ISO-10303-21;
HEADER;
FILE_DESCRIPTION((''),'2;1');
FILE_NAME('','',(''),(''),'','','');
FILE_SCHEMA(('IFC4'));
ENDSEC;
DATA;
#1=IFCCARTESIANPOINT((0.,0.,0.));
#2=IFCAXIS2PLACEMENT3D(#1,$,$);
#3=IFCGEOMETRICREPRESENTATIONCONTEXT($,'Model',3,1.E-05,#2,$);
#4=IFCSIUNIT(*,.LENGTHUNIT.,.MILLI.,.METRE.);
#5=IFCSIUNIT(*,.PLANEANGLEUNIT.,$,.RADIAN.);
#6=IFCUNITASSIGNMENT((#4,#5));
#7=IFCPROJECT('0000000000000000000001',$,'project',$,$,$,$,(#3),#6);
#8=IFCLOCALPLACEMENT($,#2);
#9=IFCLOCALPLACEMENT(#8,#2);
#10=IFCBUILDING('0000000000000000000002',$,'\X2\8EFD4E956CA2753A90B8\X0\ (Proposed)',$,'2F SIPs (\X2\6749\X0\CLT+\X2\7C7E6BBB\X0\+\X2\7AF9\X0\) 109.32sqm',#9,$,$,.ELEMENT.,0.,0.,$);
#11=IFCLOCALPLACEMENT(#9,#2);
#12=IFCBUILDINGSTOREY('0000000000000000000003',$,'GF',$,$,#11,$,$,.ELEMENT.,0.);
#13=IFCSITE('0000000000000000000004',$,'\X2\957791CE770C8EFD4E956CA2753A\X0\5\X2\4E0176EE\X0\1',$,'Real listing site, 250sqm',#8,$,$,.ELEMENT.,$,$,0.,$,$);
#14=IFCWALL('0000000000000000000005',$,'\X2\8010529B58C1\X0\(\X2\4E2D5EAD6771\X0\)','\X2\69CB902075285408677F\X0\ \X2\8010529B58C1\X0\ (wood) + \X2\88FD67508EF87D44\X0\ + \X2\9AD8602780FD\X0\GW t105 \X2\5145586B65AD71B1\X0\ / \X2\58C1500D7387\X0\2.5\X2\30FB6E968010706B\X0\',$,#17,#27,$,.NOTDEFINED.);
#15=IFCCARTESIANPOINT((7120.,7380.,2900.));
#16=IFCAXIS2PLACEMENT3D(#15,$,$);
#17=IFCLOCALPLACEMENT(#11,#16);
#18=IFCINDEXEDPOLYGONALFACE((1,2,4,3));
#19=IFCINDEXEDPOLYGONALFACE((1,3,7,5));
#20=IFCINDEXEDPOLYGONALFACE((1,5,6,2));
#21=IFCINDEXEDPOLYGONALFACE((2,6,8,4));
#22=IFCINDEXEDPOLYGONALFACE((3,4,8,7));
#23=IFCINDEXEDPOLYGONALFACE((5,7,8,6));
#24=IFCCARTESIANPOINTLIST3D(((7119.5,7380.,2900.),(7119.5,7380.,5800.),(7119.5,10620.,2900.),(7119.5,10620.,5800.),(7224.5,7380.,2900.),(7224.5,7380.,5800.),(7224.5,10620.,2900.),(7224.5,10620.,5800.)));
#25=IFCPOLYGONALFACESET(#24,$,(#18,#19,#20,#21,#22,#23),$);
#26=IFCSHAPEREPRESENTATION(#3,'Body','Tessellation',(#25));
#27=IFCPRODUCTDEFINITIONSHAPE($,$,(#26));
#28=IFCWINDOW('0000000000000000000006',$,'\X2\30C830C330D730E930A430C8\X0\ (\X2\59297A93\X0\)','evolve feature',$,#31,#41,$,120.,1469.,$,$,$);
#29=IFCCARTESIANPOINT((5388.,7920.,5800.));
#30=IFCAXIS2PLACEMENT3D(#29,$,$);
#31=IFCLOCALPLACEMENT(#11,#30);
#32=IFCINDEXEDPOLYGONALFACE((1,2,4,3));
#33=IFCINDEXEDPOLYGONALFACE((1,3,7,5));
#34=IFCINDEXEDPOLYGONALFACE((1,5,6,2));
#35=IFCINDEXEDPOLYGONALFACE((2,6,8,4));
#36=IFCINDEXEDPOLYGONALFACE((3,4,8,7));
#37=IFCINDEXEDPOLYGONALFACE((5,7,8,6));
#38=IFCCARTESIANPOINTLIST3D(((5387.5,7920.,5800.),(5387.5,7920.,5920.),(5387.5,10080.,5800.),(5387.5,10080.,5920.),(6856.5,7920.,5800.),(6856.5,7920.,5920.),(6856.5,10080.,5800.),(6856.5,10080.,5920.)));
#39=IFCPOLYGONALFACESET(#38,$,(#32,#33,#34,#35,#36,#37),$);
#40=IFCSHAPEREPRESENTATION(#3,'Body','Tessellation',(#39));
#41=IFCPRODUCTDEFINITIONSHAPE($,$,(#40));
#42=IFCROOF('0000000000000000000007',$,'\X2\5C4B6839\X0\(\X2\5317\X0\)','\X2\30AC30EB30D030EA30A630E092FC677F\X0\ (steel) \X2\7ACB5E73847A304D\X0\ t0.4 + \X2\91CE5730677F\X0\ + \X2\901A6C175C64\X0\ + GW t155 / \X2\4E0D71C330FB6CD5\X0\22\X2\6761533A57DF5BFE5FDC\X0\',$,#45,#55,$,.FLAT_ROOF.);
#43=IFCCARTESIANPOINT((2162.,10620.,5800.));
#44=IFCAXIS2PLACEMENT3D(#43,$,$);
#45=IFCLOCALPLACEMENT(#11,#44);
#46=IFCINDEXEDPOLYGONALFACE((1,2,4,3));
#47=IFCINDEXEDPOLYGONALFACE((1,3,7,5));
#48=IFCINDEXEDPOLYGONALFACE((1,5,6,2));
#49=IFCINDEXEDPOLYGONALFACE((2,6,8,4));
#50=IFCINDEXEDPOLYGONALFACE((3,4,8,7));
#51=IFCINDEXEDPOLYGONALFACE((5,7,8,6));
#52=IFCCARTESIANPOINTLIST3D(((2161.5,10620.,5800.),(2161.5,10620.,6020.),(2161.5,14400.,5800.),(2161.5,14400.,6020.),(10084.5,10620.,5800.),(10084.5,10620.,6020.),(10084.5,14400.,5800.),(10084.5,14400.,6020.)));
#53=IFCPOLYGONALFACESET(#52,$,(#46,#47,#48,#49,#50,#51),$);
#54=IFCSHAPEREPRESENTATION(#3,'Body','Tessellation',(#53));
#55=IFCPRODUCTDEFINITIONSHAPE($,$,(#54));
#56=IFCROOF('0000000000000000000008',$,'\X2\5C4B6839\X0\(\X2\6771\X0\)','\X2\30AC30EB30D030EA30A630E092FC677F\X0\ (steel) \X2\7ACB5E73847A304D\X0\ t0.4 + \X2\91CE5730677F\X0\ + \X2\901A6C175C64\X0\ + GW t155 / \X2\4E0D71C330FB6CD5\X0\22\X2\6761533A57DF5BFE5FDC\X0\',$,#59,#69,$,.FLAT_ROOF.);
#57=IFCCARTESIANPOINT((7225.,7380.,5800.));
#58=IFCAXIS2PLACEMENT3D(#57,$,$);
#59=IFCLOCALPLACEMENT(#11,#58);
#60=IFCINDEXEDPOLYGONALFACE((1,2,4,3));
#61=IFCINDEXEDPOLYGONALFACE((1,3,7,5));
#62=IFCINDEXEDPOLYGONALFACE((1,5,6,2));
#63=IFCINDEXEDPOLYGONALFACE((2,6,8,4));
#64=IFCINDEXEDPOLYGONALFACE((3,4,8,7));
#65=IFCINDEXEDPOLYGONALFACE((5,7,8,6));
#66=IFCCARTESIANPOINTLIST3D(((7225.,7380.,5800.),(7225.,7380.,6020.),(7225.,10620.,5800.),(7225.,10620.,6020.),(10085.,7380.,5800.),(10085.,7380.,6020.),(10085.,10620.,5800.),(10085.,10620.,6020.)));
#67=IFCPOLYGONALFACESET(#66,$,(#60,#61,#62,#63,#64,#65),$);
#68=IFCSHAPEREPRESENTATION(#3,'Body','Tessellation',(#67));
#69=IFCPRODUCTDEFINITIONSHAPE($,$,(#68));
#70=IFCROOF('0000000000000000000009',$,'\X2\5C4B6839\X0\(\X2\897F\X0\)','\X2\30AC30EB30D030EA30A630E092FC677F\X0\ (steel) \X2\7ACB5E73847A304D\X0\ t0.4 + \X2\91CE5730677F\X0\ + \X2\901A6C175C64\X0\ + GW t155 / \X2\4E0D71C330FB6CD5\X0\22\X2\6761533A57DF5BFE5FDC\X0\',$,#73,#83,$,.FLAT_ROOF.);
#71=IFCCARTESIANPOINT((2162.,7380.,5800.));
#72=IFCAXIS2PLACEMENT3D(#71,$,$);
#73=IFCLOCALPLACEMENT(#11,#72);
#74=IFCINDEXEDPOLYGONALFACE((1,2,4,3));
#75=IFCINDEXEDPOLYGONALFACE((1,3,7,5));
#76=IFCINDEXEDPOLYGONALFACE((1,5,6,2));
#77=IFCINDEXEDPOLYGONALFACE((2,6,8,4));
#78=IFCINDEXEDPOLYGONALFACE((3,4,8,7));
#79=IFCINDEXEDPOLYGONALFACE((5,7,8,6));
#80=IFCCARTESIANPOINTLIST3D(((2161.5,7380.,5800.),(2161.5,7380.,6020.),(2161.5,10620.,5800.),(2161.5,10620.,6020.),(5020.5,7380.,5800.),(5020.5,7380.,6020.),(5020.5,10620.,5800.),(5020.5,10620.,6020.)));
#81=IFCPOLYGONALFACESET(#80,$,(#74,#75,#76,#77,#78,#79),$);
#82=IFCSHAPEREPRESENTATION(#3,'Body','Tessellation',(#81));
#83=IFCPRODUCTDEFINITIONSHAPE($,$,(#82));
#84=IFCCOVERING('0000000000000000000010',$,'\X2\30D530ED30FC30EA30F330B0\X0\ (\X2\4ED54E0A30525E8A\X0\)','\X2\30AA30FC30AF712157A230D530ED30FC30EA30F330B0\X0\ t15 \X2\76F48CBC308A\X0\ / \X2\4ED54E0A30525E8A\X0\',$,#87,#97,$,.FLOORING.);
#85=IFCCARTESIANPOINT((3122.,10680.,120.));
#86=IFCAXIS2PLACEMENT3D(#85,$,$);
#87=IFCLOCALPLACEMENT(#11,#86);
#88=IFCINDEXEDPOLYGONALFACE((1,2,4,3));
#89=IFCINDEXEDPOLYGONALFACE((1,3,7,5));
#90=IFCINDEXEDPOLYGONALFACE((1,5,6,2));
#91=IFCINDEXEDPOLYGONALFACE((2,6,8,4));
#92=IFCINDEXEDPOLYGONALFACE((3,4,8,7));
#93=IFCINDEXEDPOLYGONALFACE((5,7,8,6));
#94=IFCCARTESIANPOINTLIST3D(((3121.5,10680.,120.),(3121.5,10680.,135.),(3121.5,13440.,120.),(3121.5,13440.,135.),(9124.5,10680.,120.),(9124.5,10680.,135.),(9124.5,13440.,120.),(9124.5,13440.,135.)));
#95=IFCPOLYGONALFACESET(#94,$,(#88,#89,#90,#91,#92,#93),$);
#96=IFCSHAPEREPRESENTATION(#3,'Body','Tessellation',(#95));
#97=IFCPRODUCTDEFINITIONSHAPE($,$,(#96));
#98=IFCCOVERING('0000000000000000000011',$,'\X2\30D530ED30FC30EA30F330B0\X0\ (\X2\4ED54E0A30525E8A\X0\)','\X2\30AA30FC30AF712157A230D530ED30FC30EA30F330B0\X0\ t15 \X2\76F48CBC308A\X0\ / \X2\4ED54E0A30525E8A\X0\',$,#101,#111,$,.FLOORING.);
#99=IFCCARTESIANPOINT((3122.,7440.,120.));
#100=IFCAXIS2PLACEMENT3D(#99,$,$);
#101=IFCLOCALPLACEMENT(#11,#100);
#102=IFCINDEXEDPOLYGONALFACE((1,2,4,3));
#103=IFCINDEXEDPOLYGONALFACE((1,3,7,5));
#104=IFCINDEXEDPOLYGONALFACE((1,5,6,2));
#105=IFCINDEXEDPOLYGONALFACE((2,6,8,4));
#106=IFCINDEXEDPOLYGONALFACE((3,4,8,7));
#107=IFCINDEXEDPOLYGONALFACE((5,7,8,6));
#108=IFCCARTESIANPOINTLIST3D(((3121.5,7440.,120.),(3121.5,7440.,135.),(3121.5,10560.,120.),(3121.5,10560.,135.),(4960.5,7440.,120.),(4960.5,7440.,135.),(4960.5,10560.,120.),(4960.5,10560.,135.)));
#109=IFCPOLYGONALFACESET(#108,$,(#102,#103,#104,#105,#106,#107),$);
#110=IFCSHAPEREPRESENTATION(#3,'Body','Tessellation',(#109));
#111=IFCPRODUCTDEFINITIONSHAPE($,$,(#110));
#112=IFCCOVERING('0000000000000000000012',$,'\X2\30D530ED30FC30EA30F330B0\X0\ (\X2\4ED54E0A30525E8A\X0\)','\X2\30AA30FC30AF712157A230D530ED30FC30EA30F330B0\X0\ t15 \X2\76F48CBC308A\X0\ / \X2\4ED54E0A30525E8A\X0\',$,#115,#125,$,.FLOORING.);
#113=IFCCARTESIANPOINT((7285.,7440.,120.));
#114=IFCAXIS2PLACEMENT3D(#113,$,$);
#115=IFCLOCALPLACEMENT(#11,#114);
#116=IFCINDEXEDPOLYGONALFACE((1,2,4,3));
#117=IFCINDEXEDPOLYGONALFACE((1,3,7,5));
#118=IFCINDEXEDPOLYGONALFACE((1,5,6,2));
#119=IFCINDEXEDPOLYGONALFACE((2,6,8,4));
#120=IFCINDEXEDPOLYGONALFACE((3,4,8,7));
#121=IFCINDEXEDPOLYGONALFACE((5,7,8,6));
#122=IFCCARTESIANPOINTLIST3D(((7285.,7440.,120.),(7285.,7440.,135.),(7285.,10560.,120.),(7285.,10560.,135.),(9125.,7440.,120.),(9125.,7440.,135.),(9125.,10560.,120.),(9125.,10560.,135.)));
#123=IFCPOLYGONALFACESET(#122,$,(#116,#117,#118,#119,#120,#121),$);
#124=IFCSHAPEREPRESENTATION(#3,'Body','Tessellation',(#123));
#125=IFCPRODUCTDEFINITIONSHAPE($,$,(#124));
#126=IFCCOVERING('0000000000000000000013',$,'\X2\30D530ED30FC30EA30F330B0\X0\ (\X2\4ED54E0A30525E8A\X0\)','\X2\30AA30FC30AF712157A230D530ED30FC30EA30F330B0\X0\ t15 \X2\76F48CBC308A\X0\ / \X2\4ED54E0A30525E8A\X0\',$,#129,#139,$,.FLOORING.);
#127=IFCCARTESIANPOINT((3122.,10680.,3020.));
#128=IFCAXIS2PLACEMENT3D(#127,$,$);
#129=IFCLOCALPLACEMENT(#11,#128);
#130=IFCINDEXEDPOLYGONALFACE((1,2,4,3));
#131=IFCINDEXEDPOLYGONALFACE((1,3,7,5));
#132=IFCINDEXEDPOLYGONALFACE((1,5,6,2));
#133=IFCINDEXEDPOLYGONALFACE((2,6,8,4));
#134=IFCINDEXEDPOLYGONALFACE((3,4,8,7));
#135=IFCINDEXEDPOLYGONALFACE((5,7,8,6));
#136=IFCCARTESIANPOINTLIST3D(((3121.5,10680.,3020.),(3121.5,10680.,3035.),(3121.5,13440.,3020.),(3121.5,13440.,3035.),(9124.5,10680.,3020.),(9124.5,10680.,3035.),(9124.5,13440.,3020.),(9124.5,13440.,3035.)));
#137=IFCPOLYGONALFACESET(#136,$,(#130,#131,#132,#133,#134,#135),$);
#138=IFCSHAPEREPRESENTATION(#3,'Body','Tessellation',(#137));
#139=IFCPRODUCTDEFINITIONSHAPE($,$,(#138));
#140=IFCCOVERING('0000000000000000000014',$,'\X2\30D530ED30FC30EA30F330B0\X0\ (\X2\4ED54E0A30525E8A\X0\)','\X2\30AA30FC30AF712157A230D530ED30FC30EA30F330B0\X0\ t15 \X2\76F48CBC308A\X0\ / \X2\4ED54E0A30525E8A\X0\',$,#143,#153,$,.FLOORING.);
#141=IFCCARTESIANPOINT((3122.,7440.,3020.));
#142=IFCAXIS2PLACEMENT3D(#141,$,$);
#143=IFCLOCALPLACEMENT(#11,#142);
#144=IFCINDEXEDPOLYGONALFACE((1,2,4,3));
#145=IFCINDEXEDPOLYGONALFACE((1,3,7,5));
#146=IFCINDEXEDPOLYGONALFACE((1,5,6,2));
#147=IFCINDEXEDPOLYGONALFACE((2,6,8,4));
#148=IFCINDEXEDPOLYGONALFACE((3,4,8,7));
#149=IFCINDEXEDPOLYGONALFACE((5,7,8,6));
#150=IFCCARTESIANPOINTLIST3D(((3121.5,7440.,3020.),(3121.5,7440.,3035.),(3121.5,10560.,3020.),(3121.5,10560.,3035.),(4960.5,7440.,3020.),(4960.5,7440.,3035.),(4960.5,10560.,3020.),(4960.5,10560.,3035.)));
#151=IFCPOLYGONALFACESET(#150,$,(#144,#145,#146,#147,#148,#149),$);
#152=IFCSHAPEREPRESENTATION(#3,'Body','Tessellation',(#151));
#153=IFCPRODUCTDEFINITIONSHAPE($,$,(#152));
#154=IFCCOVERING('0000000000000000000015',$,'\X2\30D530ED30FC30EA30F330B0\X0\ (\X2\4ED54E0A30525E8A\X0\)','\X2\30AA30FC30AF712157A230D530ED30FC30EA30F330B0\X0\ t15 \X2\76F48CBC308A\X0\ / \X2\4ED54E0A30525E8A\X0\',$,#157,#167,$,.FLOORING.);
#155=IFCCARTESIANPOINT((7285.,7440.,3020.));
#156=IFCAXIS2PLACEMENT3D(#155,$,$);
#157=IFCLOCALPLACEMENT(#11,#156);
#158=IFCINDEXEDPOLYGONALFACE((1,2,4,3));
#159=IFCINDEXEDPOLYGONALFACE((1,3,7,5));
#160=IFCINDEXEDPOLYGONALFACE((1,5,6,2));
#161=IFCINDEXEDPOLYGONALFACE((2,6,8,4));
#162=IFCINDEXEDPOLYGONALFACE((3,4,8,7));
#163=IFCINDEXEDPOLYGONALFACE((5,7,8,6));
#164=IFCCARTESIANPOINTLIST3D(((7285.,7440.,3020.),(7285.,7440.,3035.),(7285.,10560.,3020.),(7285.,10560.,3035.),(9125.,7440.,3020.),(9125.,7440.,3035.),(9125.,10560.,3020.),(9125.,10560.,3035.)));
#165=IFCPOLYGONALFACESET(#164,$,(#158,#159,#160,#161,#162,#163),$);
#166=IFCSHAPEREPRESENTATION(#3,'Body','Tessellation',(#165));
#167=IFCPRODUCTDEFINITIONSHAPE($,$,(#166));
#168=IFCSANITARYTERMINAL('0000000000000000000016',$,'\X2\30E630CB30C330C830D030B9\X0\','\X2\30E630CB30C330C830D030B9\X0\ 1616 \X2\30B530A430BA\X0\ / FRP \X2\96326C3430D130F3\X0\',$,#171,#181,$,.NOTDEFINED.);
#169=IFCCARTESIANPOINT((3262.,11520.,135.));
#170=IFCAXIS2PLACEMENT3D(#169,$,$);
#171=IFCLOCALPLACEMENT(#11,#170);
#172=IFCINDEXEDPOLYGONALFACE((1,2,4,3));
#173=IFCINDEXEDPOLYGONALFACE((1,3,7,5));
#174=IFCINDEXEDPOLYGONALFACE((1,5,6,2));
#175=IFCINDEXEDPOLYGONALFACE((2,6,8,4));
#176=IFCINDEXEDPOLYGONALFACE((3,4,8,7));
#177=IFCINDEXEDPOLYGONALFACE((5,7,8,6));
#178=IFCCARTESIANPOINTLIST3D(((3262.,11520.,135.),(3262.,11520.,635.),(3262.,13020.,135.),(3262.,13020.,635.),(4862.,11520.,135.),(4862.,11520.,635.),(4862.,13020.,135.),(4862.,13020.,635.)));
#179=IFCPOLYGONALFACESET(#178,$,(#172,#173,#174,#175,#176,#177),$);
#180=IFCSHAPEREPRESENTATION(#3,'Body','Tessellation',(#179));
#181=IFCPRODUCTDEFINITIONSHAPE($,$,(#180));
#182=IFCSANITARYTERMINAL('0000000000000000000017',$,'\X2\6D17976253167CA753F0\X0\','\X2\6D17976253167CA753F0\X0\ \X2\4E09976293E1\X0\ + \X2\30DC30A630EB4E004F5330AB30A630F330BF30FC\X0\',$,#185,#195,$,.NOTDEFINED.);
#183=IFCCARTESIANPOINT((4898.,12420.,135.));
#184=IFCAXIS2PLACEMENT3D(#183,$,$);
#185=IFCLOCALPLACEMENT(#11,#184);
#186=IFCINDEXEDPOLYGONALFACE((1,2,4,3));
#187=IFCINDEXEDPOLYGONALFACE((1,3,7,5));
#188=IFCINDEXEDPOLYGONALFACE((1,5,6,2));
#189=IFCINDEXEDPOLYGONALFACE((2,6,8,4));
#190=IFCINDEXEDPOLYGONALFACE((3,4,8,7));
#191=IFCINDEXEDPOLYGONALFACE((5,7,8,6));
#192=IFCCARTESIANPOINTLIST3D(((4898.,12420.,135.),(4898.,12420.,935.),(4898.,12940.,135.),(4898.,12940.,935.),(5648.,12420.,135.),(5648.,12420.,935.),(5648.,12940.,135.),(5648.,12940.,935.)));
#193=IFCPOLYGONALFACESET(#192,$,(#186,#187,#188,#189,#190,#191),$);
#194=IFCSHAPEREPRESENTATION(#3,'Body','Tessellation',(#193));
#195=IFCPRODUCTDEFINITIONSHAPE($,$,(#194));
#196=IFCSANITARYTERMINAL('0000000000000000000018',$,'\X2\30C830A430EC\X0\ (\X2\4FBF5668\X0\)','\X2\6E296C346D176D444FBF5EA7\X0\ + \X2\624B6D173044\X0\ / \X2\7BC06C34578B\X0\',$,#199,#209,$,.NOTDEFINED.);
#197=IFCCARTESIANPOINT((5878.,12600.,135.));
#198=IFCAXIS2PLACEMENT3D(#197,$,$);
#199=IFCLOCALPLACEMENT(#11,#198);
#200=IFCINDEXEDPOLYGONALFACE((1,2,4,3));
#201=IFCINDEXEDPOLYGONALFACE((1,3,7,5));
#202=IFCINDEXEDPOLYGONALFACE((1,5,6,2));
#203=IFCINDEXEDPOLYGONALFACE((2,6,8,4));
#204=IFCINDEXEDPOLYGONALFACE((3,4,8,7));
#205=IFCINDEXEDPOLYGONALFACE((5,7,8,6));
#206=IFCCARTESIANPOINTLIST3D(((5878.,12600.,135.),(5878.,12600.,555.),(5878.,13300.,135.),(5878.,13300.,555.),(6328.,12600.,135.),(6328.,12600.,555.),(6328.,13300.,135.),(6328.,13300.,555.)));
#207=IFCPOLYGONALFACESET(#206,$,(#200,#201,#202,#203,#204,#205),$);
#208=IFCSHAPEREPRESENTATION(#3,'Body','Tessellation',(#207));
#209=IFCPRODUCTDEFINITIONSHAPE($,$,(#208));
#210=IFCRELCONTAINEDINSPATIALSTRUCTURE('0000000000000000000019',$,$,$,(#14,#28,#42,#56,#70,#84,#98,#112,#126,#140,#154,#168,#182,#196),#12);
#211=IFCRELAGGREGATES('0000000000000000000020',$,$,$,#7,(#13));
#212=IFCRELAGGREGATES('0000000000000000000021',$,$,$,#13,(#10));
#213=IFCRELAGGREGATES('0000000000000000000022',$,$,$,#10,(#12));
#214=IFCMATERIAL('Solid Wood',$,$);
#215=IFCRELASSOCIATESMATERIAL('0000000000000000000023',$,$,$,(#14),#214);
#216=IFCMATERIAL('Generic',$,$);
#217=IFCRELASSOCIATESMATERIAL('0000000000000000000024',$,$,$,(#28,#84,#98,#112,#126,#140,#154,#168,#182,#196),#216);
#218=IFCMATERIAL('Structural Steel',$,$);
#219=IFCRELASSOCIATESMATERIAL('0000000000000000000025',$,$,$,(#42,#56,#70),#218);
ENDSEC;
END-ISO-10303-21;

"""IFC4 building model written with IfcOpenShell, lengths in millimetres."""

from ifc_helpers import new_model, si_unit, frame, frame_2d, origin, place, context, project, spatial, rectangle, extrude, material, element, save


model = new_model("IFC4")

# Units and contexts
model_context = context("Model", 3, precision=1e-05, world=origin())
ifc_project = project(units=[si_unit("LENGTHUNIT", "METRE", prefix="MILLI"), si_unit("PLANEANGLEUNIT", "RADIAN")], contexts=[model_context])

# Site, building, storey
site_placement = place(None, origin())
site = spatial("IfcSite", under=ifc_project, at=site_placement, Name="長野県軽井沢町5丁目1", ObjectType="Real listing site, 250sqm", CompositionType="ELEMENT", RefElevation=0.0)
building_placement = place(site_placement, origin())
building = spatial("IfcBuilding", under=site, at=building_placement, Name="軽井沢町邸 (Proposed)", ObjectType="2F SIPs (杉CLT+籾殻+竹) 109.32sqm", CompositionType="ELEMENT", ElevationOfRefHeight=0.0, ElevationOfTerrain=0.0)
storey_placement = place(building_placement, origin())
storey = spatial("IfcBuildingStorey", under=building, at=storey_placement, Name="GF", CompositionType="ELEMENT", Elevation=0.0)

# Shared definitions
ifc_material_1 = material(Name="Solid Wood")

# Wall
wall_1_placement = place(storey_placement, frame((7120.0, 7380.0, 2900.0)))
element("IfcWall", 1, at=wall_1_placement, inside=storey, material=ifc_material_1, Name="耐力壁(中庭東)", Description="構造用合板 耐力壁 (wood) + 製材軸組 + 高性能GW t105 充填断熱 / 壁倍率2.5・準耐火", PredefinedType="NOTDEFINED", context=model_context, shape_type="SweptSolid", body=[
    extrude(rectangle(XDim=105.0, YDim=3240.0, at=frame_2d((52.0, 1620.0))), frame((7120.0, 7380.0, 2900.0)), (0.0, 0.0, 1.0), 2900.0),
])

# Window
ifc_material_2 = material(Name="Generic")
window_1_placement = place(storey_placement, frame((5388.0, 7920.0, 5800.0)))
element("IfcWindow", 2, at=window_1_placement, inside=storey, material=ifc_material_2, Name="トップライト (天窓)", Description="evolve feature", OverallHeight=120.0, OverallWidth=1469.0, context=model_context, shape_type="SweptSolid", body=[
    extrude(rectangle(XDim=1469.0, YDim=2160.0, at=frame_2d((734.0, 1080.0))), frame((5388.0, 7920.0, 5800.0)), (0.0, 0.0, 1.0), 120.0),
])

# Roofs
ifc_material_3 = material(Name="Structural Steel")
roof_1_placement = place(storey_placement, frame((2162.0, 10620.0, 5800.0)))
element("IfcRoof", 3, at=roof_1_placement, inside=storey, material=ifc_material_3, Name="屋根(北)", Description="ガルバリウム鋼板 (steel) 立平葺き t0.4 + 野地板 + 通気層 + GW t155 / 不燃・法22条区域対応", PredefinedType="FLAT_ROOF", context=model_context, shape_type="SweptSolid", body=[
    extrude(rectangle(XDim=7923.0, YDim=3780.0, at=frame_2d((3961.0, 1890.0))), frame((2162.0, 10620.0, 5800.0)), (0.0, 0.0, 1.0), 220.0),
])
roof_2_placement = place(storey_placement, frame((7225.0, 7380.0, 5800.0)))
element("IfcRoof", 4, at=roof_2_placement, inside=storey, material=ifc_material_3, Name="屋根(東)", Description="ガルバリウム鋼板 (steel) 立平葺き t0.4 + 野地板 + 通気層 + GW t155 / 不燃・法22条区域対応", PredefinedType="FLAT_ROOF", context=model_context, shape_type="SweptSolid", body=[
    extrude(rectangle(XDim=2860.0, YDim=3240.0, at=frame_2d((1430.0, 1620.0))), frame((7225.0, 7380.0, 5800.0)), (0.0, 0.0, 1.0), 220.0),
])
roof_3_placement = place(storey_placement, frame((2162.0, 7380.0, 5800.0)))
element("IfcRoof", 5, at=roof_3_placement, inside=storey, material=ifc_material_3, Name="屋根(西)", Description="ガルバリウム鋼板 (steel) 立平葺き t0.4 + 野地板 + 通気層 + GW t155 / 不燃・法22条区域対応", PredefinedType="FLAT_ROOF", context=model_context, shape_type="SweptSolid", body=[
    extrude(rectangle(XDim=2859.0, YDim=3240.0, at=frame_2d((1429.0, 1620.0))), frame((2162.0, 7380.0, 5800.0)), (0.0, 0.0, 1.0), 220.0),
])

# Coverings
covering_1_placement = place(storey_placement, frame((3122.0, 10680.0, 120.0)))
element("IfcCovering", 6, at=covering_1_placement, inside=storey, material=ifc_material_2, Name="フローリング (仕上げ床)", Description="オーク無垢フローリング t15 直貼り / 仕上げ床", PredefinedType="FLOORING", context=model_context, shape_type="SweptSolid", body=[
    extrude(rectangle(XDim=6003.0, YDim=2760.0, at=frame_2d((3001.0, 1380.0))), frame((3122.0, 10680.0, 120.0)), (0.0, 0.0, 1.0), 15.0),
])
covering_2_placement = place(storey_placement, frame((3122.0, 7440.0, 120.0)))
element("IfcCovering", 7, at=covering_2_placement, inside=storey, material=ifc_material_2, Name="フローリング (仕上げ床)", Description="オーク無垢フローリング t15 直貼り / 仕上げ床", PredefinedType="FLOORING", context=model_context, shape_type="SweptSolid", body=[
    extrude(rectangle(XDim=1839.0, YDim=3120.0, at=frame_2d((919.0, 1560.0))), frame((3122.0, 7440.0, 120.0)), (0.0, 0.0, 1.0), 15.0),
])
covering_3_placement = place(storey_placement, frame((7285.0, 7440.0, 120.0)))
element("IfcCovering", 8, at=covering_3_placement, inside=storey, material=ifc_material_2, Name="フローリング (仕上げ床)", Description="オーク無垢フローリング t15 直貼り / 仕上げ床", PredefinedType="FLOORING", context=model_context, shape_type="SweptSolid", body=[
    extrude(rectangle(XDim=1840.0, YDim=3120.0, at=frame_2d((920.0, 1560.0))), frame((7285.0, 7440.0, 120.0)), (0.0, 0.0, 1.0), 15.0),
])
covering_4_placement = place(storey_placement, frame((3122.0, 10680.0, 3020.0)))
element("IfcCovering", 9, at=covering_4_placement, inside=storey, material=ifc_material_2, Name="フローリング (仕上げ床)", Description="オーク無垢フローリング t15 直貼り / 仕上げ床", PredefinedType="FLOORING", context=model_context, shape_type="SweptSolid", body=[
    extrude(rectangle(XDim=6003.0, YDim=2760.0, at=frame_2d((3001.0, 1380.0))), frame((3122.0, 10680.0, 3020.0)), (0.0, 0.0, 1.0), 15.0),
])
covering_5_placement = place(storey_placement, frame((3122.0, 7440.0, 3020.0)))
element("IfcCovering", 10, at=covering_5_placement, inside=storey, material=ifc_material_2, Name="フローリング (仕上げ床)", Description="オーク無垢フローリング t15 直貼り / 仕上げ床", PredefinedType="FLOORING", context=model_context, shape_type="SweptSolid", body=[
    extrude(rectangle(XDim=1839.0, YDim=3120.0, at=frame_2d((919.0, 1560.0))), frame((3122.0, 7440.0, 3020.0)), (0.0, 0.0, 1.0), 15.0),
])
covering_6_placement = place(storey_placement, frame((7285.0, 7440.0, 3020.0)))
element("IfcCovering", 11, at=covering_6_placement, inside=storey, material=ifc_material_2, Name="フローリング (仕上げ床)", Description="オーク無垢フローリング t15 直貼り / 仕上げ床", PredefinedType="FLOORING", context=model_context, shape_type="SweptSolid", body=[
    extrude(rectangle(XDim=1840.0, YDim=3120.0, at=frame_2d((920.0, 1560.0))), frame((7285.0, 7440.0, 3020.0)), (0.0, 0.0, 1.0), 15.0),
])

# Sanitary terminals
sanitary_terminal_1_placement = place(storey_placement, frame((3262.0, 11520.0, 135.0)))
element("IfcSanitaryTerminal", 12, at=sanitary_terminal_1_placement, inside=storey, material=ifc_material_2, Name="ユニットバス", Description="ユニットバス 1616 サイズ / FRP 防水パン", PredefinedType="NOTDEFINED", context=model_context, shape_type="SweptSolid", body=[
    extrude(rectangle(XDim=1600.0, YDim=1500.0, at=frame_2d((800.0, 750.0))), frame((3262.0, 11520.0, 135.0)), (0.0, 0.0, 1.0), 500.0),
])
sanitary_terminal_2_placement = place(storey_placement, frame((4898.0, 12420.0, 135.0)))
element("IfcSanitaryTerminal", 13, at=sanitary_terminal_2_placement, inside=storey, material=ifc_material_2, Name="洗面化粧台", Description="洗面化粧台 三面鏡 + ボウル一体カウンター", PredefinedType="NOTDEFINED", context=model_context, shape_type="SweptSolid", body=[
    extrude(rectangle(XDim=750.0, YDim=520.0, at=frame_2d((375.0, 260.0))), frame((4898.0, 12420.0, 135.0)), (0.0, 0.0, 1.0), 800.0),
])
sanitary_terminal_3_placement = place(storey_placement, frame((5878.0, 12600.0, 135.0)))
element("IfcSanitaryTerminal", 14, at=sanitary_terminal_3_placement, inside=storey, material=ifc_material_2, Name="トイレ (便器)", Description="温水洗浄便座 + 手洗い / 節水型", PredefinedType="NOTDEFINED", context=model_context, shape_type="SweptSolid", body=[
    extrude(rectangle(XDim=450.0, YDim=700.0, at=frame_2d((225.0, 350.0))), frame((5878.0, 12600.0, 135.0)), (0.0, 0.0, 1.0), 420.0),
])

save(model, "model.ifc")
